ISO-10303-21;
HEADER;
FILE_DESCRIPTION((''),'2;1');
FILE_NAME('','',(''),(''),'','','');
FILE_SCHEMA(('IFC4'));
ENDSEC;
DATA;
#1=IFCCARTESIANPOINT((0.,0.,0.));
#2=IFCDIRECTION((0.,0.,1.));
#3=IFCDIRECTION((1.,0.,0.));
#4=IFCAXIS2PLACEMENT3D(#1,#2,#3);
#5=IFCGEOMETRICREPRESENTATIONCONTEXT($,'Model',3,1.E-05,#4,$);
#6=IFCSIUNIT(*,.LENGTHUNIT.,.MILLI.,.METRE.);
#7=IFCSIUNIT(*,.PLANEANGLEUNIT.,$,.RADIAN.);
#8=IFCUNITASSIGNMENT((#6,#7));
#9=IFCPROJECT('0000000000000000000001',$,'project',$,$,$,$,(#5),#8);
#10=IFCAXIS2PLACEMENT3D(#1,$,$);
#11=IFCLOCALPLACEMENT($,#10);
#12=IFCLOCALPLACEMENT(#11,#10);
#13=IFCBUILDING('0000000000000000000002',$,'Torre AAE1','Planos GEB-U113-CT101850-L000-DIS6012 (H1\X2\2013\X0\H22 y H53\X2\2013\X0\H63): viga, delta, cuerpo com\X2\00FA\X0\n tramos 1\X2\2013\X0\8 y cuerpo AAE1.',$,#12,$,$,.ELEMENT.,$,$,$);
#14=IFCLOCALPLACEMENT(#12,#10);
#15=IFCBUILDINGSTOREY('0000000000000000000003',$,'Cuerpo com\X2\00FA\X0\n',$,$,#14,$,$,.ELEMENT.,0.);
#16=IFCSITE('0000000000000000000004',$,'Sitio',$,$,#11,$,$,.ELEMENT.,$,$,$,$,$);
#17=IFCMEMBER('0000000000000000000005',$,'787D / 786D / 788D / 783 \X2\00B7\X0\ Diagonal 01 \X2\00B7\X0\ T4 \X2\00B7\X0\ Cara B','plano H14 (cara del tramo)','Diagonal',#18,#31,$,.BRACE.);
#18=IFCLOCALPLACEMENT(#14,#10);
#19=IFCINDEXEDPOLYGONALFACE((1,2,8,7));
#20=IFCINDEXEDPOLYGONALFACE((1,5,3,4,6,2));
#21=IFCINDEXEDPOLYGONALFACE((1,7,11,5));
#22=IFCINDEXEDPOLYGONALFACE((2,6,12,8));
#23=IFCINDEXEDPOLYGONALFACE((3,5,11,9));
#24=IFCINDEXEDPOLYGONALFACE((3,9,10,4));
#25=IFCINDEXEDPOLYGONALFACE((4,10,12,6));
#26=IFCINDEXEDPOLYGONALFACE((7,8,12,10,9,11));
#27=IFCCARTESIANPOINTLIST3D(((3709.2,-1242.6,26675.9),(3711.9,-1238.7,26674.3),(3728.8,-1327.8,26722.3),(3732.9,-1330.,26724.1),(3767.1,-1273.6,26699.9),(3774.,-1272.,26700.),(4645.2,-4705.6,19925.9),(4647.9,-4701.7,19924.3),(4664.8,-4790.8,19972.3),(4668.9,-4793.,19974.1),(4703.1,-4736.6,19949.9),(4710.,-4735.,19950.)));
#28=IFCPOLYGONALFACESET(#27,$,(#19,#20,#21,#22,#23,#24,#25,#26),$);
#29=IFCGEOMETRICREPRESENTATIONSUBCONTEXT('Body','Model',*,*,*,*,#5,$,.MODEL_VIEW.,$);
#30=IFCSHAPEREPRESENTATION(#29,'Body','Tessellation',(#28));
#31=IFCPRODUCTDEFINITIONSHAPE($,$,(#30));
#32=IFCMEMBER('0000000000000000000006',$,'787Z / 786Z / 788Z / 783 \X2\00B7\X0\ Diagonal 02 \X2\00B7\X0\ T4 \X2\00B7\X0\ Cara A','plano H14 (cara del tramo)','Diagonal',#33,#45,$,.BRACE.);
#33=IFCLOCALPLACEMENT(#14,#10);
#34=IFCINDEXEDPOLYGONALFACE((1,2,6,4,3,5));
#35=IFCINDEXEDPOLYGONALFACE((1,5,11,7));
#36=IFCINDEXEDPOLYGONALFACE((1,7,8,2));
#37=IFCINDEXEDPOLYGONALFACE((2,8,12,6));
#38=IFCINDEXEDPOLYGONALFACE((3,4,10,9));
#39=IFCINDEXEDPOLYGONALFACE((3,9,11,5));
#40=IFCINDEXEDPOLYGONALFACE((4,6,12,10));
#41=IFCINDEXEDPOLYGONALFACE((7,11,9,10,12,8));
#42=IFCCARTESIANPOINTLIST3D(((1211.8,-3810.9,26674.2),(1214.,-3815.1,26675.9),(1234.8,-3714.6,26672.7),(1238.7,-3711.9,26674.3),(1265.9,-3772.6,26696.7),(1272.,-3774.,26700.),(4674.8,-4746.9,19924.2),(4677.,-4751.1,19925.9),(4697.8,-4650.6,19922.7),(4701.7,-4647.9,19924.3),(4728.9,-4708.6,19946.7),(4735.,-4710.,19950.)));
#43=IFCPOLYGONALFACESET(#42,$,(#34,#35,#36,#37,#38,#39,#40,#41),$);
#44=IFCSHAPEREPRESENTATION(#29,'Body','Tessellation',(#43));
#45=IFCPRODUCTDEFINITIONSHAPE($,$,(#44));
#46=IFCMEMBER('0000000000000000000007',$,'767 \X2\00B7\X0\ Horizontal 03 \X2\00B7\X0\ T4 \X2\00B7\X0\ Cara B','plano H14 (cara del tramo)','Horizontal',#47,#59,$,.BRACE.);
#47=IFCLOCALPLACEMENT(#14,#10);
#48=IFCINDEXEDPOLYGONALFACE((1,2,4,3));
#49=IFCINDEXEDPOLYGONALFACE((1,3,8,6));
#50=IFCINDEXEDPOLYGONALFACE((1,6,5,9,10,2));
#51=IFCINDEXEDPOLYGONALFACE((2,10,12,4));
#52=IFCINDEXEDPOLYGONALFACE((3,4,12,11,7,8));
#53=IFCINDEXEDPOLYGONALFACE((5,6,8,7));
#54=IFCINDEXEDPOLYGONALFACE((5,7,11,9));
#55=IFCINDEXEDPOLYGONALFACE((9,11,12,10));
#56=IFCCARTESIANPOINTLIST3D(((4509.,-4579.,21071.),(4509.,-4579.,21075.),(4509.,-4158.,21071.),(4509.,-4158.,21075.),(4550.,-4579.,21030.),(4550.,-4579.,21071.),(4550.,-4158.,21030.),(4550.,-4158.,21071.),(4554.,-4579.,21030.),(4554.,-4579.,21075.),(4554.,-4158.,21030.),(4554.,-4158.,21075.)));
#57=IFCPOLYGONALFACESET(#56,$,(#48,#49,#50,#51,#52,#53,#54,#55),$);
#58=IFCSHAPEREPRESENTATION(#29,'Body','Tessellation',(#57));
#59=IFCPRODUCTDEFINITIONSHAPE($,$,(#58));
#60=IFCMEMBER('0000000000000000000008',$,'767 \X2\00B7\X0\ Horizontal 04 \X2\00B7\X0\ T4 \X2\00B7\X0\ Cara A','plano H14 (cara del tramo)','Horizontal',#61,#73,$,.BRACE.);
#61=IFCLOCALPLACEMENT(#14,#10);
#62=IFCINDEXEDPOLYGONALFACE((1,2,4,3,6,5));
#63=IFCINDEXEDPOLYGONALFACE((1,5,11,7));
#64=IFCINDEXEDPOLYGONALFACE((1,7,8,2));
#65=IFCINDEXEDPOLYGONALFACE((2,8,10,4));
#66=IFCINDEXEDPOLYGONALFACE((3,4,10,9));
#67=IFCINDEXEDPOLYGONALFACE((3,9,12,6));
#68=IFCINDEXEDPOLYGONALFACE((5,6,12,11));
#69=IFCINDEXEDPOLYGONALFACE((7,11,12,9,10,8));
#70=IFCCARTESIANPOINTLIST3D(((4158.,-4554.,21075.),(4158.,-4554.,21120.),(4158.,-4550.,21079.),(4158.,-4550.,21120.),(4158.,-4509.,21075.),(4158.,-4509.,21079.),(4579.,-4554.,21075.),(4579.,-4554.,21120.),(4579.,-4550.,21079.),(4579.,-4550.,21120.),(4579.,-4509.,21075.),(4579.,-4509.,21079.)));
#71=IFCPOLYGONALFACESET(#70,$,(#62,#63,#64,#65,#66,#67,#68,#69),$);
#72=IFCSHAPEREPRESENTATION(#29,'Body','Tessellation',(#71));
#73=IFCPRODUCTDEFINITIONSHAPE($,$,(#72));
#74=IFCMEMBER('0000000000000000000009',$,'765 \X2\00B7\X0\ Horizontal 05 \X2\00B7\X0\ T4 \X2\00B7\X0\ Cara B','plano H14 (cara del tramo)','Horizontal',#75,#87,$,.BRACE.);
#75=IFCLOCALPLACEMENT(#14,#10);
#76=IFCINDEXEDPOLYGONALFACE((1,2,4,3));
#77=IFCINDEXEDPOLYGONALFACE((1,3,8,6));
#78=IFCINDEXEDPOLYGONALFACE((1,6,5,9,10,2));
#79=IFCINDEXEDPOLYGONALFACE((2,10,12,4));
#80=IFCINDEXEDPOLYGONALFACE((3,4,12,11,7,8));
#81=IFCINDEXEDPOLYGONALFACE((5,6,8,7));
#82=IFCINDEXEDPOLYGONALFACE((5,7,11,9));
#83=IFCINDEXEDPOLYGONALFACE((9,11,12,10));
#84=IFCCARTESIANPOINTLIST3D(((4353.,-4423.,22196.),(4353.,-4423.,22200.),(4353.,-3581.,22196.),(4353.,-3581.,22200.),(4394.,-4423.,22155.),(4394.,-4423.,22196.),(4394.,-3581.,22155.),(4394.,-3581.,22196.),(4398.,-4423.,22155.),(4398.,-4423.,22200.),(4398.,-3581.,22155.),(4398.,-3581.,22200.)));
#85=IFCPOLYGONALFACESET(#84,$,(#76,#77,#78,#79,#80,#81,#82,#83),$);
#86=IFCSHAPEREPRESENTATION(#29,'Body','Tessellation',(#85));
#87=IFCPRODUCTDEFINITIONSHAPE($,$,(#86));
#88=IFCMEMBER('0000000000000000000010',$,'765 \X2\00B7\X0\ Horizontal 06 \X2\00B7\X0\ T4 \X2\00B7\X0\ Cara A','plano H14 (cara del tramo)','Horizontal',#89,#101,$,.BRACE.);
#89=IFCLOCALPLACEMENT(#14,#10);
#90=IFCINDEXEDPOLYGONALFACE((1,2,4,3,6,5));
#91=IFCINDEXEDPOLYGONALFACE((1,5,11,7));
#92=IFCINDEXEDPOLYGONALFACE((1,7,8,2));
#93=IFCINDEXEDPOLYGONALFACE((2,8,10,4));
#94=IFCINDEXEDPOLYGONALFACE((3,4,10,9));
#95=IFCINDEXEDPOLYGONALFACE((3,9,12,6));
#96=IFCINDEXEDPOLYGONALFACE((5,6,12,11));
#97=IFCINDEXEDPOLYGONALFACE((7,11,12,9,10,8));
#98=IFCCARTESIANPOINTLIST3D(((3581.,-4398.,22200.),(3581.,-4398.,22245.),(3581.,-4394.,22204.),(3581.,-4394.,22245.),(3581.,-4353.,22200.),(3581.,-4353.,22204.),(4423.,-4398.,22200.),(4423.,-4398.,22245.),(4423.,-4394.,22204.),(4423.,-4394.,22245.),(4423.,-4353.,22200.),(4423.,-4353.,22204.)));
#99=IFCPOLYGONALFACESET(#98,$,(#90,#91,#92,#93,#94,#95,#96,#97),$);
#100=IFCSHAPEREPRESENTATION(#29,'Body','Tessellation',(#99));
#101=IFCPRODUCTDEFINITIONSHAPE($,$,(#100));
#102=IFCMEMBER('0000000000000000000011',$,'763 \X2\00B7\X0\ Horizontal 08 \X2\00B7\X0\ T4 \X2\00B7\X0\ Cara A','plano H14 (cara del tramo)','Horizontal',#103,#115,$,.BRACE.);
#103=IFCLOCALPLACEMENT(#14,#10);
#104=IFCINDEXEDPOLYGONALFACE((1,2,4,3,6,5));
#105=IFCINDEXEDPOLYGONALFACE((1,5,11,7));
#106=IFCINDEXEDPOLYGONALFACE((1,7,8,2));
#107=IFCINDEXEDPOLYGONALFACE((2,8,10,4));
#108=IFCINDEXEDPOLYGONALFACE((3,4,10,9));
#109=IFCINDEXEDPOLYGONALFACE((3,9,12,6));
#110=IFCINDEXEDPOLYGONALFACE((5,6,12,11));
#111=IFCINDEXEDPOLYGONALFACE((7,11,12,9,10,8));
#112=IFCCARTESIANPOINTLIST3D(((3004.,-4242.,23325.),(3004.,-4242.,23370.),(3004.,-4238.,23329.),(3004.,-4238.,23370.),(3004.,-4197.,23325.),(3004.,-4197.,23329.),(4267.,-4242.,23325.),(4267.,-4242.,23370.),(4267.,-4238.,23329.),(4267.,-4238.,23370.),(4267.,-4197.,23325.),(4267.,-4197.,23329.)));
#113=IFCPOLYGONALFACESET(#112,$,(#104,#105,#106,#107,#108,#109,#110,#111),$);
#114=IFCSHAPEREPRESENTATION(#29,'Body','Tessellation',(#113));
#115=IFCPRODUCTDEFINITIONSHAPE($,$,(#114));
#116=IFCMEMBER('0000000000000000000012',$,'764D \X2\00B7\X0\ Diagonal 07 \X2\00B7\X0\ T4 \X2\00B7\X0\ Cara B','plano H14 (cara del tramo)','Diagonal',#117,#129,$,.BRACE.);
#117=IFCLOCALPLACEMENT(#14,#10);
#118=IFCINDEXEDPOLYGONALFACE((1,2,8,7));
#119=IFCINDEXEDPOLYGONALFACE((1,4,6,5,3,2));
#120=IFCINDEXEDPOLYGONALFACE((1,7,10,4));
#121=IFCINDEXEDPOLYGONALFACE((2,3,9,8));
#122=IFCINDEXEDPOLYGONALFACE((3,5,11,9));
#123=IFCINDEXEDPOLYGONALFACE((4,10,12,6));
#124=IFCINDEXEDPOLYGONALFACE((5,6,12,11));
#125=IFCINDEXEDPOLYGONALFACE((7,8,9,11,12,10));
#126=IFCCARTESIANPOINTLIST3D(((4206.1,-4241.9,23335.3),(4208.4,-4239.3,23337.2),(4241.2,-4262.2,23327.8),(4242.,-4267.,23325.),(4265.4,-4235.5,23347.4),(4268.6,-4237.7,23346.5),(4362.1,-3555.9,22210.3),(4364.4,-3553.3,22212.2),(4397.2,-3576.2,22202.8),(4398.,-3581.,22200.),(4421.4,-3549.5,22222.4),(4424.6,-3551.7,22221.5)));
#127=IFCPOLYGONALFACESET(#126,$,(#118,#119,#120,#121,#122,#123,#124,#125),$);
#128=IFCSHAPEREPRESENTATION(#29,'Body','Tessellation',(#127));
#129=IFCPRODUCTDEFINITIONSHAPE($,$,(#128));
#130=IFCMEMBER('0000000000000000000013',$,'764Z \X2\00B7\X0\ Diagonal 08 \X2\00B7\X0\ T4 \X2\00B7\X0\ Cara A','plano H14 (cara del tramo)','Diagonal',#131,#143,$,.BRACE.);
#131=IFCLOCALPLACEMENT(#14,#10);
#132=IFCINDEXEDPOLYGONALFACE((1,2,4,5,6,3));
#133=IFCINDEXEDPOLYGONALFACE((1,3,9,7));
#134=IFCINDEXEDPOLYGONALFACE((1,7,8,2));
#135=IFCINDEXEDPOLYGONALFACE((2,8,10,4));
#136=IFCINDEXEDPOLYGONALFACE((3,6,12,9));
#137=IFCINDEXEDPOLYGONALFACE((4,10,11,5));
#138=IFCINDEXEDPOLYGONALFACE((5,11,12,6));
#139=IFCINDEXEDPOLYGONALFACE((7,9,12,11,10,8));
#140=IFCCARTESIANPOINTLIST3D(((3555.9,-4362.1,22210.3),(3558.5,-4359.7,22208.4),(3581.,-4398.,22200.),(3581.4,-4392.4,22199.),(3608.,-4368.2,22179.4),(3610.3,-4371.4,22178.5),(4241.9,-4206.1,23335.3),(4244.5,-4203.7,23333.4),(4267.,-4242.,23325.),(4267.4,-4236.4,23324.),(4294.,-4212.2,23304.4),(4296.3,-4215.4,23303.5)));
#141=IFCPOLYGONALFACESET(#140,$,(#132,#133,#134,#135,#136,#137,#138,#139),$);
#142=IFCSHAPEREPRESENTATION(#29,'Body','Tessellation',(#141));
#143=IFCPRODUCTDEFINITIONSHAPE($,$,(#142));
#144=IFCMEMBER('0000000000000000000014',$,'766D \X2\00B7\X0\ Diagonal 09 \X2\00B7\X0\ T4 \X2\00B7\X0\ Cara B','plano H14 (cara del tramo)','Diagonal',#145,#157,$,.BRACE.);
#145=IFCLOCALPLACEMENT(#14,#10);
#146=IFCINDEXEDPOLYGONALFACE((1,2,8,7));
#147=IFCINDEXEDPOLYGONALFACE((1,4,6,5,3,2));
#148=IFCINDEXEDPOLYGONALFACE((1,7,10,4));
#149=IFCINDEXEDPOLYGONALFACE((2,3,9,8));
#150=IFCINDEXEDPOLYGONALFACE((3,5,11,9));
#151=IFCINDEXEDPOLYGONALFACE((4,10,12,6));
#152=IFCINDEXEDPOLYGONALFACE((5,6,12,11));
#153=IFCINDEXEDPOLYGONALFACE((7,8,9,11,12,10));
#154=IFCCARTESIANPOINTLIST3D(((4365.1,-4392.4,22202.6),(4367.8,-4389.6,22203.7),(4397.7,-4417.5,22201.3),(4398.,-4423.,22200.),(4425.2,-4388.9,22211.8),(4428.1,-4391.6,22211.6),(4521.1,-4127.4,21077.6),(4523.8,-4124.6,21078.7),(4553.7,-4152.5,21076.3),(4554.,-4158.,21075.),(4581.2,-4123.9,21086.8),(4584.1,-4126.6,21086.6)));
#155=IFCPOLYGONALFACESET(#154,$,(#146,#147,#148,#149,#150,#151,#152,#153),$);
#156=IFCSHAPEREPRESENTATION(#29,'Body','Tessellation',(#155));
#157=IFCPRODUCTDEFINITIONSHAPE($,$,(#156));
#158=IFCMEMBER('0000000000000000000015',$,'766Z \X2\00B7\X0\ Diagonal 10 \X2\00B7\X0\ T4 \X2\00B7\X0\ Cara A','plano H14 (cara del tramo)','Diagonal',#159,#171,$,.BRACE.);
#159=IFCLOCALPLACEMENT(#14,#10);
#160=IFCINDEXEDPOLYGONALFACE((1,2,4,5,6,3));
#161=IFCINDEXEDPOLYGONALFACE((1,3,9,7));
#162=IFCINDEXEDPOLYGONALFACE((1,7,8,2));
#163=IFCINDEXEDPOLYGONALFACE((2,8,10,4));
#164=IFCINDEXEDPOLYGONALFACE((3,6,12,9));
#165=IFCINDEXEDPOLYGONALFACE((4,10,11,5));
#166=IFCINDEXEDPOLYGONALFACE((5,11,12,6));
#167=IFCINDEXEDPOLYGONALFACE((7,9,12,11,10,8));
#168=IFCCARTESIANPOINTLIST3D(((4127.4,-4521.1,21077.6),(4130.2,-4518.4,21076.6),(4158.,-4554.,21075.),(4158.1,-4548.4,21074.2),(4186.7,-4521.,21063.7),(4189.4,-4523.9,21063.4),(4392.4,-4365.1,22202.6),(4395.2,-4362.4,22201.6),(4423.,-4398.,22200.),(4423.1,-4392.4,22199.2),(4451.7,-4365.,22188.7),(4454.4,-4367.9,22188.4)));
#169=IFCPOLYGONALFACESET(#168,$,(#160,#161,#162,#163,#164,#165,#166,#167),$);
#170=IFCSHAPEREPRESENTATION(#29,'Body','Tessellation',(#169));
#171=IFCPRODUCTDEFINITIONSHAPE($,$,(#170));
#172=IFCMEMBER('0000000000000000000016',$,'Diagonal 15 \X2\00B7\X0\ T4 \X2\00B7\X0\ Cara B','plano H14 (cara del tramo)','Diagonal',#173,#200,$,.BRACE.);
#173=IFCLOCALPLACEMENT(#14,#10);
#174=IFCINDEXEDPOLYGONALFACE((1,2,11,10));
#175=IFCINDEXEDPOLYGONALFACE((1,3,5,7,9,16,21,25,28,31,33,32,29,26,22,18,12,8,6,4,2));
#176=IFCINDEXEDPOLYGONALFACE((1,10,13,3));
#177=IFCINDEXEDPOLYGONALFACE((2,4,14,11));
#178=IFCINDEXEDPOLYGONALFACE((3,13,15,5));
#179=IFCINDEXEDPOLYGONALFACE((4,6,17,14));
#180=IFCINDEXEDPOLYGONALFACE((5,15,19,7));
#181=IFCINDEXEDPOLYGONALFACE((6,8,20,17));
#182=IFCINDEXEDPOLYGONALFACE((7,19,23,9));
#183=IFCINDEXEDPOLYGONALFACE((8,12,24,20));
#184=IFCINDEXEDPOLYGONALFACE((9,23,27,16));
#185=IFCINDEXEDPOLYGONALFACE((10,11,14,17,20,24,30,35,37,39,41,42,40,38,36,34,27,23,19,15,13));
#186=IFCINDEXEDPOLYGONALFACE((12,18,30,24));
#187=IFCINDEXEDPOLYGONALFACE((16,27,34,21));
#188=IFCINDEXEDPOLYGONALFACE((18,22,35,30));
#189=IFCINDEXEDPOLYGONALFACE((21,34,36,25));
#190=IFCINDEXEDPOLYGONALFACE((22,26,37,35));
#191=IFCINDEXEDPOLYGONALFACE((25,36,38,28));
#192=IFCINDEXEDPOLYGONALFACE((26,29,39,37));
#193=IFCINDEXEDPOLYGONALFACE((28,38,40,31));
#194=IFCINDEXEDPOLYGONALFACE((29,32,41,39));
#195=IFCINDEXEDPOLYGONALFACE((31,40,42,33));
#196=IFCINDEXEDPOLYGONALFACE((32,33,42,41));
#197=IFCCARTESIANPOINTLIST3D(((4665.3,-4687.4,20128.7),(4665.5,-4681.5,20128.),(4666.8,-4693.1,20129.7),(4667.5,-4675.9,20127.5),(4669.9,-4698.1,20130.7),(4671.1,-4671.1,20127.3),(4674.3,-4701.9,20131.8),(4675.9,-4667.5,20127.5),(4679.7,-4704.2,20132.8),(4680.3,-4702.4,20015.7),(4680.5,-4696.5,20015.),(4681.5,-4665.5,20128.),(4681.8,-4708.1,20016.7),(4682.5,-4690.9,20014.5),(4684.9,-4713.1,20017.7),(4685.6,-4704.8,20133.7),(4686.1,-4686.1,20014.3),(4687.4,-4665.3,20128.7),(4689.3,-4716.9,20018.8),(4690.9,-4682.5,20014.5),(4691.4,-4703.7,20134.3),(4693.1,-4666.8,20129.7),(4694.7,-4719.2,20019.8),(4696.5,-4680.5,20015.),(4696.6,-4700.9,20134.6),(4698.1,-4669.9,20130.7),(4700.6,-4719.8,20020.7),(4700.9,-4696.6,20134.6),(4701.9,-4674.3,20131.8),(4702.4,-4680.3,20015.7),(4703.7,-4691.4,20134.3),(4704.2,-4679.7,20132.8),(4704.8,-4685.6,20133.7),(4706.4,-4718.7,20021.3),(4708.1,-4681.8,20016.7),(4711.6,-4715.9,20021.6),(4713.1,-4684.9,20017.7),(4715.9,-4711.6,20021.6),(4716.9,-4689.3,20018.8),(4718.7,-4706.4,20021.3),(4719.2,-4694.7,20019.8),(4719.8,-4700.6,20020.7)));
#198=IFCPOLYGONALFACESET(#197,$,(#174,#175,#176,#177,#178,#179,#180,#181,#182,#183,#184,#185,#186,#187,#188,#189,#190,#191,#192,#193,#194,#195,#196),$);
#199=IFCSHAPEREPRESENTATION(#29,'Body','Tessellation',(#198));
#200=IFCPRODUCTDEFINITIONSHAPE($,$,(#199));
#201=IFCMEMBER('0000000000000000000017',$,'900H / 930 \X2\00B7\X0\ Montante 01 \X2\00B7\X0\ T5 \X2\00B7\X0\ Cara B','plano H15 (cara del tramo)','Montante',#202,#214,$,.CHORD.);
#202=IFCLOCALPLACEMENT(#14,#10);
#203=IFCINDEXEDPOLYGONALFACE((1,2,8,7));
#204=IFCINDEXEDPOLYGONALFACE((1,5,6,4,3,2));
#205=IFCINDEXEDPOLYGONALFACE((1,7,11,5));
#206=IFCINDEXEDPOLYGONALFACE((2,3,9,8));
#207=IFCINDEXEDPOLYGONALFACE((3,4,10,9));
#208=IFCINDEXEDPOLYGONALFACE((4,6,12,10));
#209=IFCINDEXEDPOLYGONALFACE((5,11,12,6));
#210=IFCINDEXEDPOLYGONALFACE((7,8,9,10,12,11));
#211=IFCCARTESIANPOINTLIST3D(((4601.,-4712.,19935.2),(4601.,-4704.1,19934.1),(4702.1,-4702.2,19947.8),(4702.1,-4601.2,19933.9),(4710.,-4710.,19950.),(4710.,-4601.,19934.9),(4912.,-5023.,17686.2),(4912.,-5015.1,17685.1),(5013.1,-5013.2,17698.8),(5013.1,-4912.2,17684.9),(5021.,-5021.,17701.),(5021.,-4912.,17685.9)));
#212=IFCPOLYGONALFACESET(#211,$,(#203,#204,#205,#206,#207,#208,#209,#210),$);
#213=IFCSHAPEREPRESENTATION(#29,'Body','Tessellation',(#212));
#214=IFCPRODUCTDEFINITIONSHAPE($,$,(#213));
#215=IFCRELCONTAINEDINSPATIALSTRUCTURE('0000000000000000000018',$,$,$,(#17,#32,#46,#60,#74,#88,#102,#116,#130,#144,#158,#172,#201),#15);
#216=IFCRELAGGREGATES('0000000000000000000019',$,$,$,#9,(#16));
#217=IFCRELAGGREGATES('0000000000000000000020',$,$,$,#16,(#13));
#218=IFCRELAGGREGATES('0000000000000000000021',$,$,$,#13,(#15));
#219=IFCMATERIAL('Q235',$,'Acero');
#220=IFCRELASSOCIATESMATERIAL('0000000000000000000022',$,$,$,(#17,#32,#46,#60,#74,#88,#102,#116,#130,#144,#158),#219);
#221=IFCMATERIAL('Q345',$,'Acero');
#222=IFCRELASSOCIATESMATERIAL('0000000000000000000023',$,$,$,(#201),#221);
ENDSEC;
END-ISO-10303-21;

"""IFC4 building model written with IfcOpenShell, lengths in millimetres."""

from ifc_helpers import new_model, si_unit, frame, frame_2d, origin, origin_with_axes, place, context, subcontext, project, spatial, circle, l_section, extrude, material, element, save


model = new_model("IFC4")

# Units and contexts
model_context = context("Model", 3, precision=1e-05, world=origin_with_axes())
body_context = subcontext(model_context, "Body", "Model", "MODEL_VIEW")
ifc_project = project(units=[si_unit("LENGTHUNIT", "METRE", prefix="MILLI"), si_unit("PLANEANGLEUNIT", "RADIAN")], contexts=[model_context])

# Site, building, storey
site_placement = place(None, origin())
site = spatial("IfcSite", under=ifc_project, at=site_placement, Name="Sitio", CompositionType="ELEMENT")
building_placement = place(site_placement, origin())
building = spatial("IfcBuilding", under=site, at=building_placement, Name="Torre AAE1", Description="Planos GEB-U113-CT101850-L000-DIS6012 (H1–H22 y H53–H63): viga, delta, cuerpo común tramos 1–8 y cuerpo AAE1.", CompositionType="ELEMENT")
storey_placement = place(building_placement, origin())
storey = spatial("IfcBuildingStorey", under=building, at=storey_placement, Name="Cuerpo común", CompositionType="ELEMENT", Elevation=0.0)

# Members
ifc_material_1 = material(Name="Q235", Category="Acero")
for number, where, z_axis, x_axis, name in (
    (1, (4710.0, -4735.0, 19950.0), (-0.122449, 0.453034, 0.883044), (-0.827907, 0.444053, -0.342619), "787D / 786D / 788D / 783 · Diagonal 01 · T4 · Cara B"),
    (2, (4735.0, -4710.0, 19950.0), (-0.453034, 0.122449, 0.883044), (-0.444053, 0.827907, -0.342619), "787Z / 786Z / 788Z / 783 · Diagonal 02 · T4 · Cara A"),
):
    element("IfcMember", number, at=place(storey_placement, frame(where, z_axis=z_axis, x_axis=x_axis)), inside=storey, material=ifc_material_1, Name=name, Description="plano H14 (cara del tramo)", ObjectType="Diagonal", PredefinedType="BRACE", context=body_context, shape_type="SweptSolid", body=[
        extrude(l_section(Depth=75.0, Width=75.0, Thickness=5.0, at=frame_2d((37.5, 37.5))), None, (0.0, 0.0, 1.0), 7644.0),
    ])
for number, where, z_axis, x_axis, name in (
    (3, (4554.0, -4158.0, 21075.0), (0.0, -1.0, 0.0), (-1.0, 0.0, 0.0), "767 · Horizontal 03 · T4 · Cara B"),
    (4, (4158.0, -4554.0, 21075.0), (1.0, 0.0, 0.0), (0.0, 1.0, 0.0), "767 · Horizontal 04 · T4 · Cara A"),
):
    element("IfcMember", number, at=place(storey_placement, frame(where, z_axis=z_axis, x_axis=x_axis)), inside=storey, material=ifc_material_1, Name=name, Description="plano H14 (cara del tramo)", ObjectType="Horizontal", PredefinedType="BRACE", context=body_context, shape_type="SweptSolid", body=[
        extrude(l_section(Depth=45.0, Width=45.0, Thickness=4.0, at=frame_2d((22.5, 22.5))), None, (0.0, 0.0, 1.0), 421.0),
    ])
for number, where, z_axis, x_axis, name in (
    (5, (4398.0, -3581.0, 22200.0), (0.0, -1.0, 0.0), (-1.0, 0.0, 0.0), "765 · Horizontal 05 · T4 · Cara B"),
    (6, (3581.0, -4398.0, 22200.0), (1.0, 0.0, 0.0), (0.0, 1.0, 0.0), "765 · Horizontal 06 · T4 · Cara A"),
):
    element("IfcMember", number, at=place(storey_placement, frame(where, z_axis=z_axis, x_axis=x_axis)), inside=storey, material=ifc_material_1, Name=name, Description="plano H14 (cara del tramo)", ObjectType="Horizontal", PredefinedType="BRACE", context=body_context, shape_type="SweptSolid", body=[
        extrude(l_section(Depth=45.0, Width=45.0, Thickness=4.0, at=frame_2d((22.5, 22.5))), None, (0.0, 0.0, 1.0), 842.0),
    ])
member_1_placement = place(storey_placement, frame((3004.0, -4242.0, 23325.0), z_axis=(1.0, 0.0, 0.0), x_axis=(0.0, 1.0, 0.0)))
element("IfcMember", 7, at=member_1_placement, inside=storey, material=ifc_material_1, Name="763 · Horizontal 08 · T4 · Cara A", Description="plano H14 (cara del tramo)", ObjectType="Horizontal", PredefinedType="BRACE", context=body_context, shape_type="SweptSolid", body=[
    extrude(l_section(Depth=45.0, Width=45.0, Thickness=4.0, at=frame_2d((22.5, 22.5))), None, (0.0, 0.0, 1.0), 1263.0),
])
for number, where, z_axis, x_axis, name in (
    (8, (4242.0, -4267.0, 23325.0), (0.117571, 0.51701, -0.847867), (-0.798444, 0.556878, 0.228854), "764D · Diagonal 07 · T4 · Cara B"),
    (9, (4267.0, -4242.0, 23325.0), (-0.51701, -0.117571, -0.847867), (-0.556878, 0.798444, 0.228854), "764Z · Diagonal 08 · T4 · Cara A"),
):
    element("IfcMember", number, at=place(storey_placement, frame(where, z_axis=z_axis, x_axis=x_axis)), inside=storey, material=ifc_material_1, Name=name, Description="plano H14 (cara del tramo)", ObjectType="Diagonal", PredefinedType="BRACE", context=body_context, shape_type="SweptSolid", body=[
        extrude(l_section(Depth=45.0, Width=45.0, Thickness=4.0, at=frame_2d((22.5, 22.5))), None, (0.0, 0.0, 1.0), 1326.9),
    ])
for number, where, z_axis, x_axis, name in (
    (10, (4398.0, -4423.0, 22200.0), (0.13376, 0.22722, -0.964614), (-0.73137, 0.679455, 0.058633), "766D · Diagonal 09 · T4 · Cara B"),
    (11, (4423.0, -4398.0, 22200.0), (-0.22722, -0.13376, -0.964614), (-0.679455, 0.73137, 0.058633), "766Z · Diagonal 10 · T4 · Cara A"),
):
    element("IfcMember", number, at=place(storey_placement, frame(where, z_axis=z_axis, x_axis=x_axis)), inside=storey, material=ifc_material_1, Name=name, Description="plano H14 (cara del tramo)", ObjectType="Diagonal", PredefinedType="BRACE", context=body_context, shape_type="SweptSolid", body=[
        extrude(l_section(Depth=45.0, Width=45.0, Thickness=4.0, at=frame_2d((22.5, 22.5))), None, (0.0, 0.0, 1.0), 1166.3),
    ])
member_2_placement = place(storey_placement, frame((4685.0, -4685.0, 20131.0), z_axis=(0.130464, -0.130464, -0.982832), x_axis=(-0.694967, 0.694967, -0.184504)))
element("IfcMember", 12, at=member_2_placement, inside=storey, Name="Diagonal 15 · T4 · Cara B", Description="plano H14 (cara del tramo)", ObjectType="Diagonal", PredefinedType="BRACE", context=body_context, shape_type="SweptSolid", body=[
    extrude(circle(Radius=20.0), None, (0.0, 0.0, 1.0), 115.0),
])
ifc_material_2 = material(Name="Q345", Category="Acero")
member_3_placement = place(storey_placement, frame((4710.0, -4710.0, 19950.0), z_axis=(0.135713, -0.135713, -0.981409), x_axis=(-0.990748, -0.01859, -0.134434)))
element("IfcMember", 13, at=member_3_placement, inside=storey, material=ifc_material_2, Name="900H / 930 · Montante 01 · T5 · Cara B", Description="plano H15 (cara del tramo)", ObjectType="Montante", PredefinedType="CHORD", context=body_context, shape_type="SweptSolid", body=[
    extrude(l_section(Depth=110.0, Width=110.0, Thickness=8.0, at=frame_2d((55.0, 55.0))), None, (0.0, 0.0, 1.0), 2291.6),
])

save(model, "model.ifc")
